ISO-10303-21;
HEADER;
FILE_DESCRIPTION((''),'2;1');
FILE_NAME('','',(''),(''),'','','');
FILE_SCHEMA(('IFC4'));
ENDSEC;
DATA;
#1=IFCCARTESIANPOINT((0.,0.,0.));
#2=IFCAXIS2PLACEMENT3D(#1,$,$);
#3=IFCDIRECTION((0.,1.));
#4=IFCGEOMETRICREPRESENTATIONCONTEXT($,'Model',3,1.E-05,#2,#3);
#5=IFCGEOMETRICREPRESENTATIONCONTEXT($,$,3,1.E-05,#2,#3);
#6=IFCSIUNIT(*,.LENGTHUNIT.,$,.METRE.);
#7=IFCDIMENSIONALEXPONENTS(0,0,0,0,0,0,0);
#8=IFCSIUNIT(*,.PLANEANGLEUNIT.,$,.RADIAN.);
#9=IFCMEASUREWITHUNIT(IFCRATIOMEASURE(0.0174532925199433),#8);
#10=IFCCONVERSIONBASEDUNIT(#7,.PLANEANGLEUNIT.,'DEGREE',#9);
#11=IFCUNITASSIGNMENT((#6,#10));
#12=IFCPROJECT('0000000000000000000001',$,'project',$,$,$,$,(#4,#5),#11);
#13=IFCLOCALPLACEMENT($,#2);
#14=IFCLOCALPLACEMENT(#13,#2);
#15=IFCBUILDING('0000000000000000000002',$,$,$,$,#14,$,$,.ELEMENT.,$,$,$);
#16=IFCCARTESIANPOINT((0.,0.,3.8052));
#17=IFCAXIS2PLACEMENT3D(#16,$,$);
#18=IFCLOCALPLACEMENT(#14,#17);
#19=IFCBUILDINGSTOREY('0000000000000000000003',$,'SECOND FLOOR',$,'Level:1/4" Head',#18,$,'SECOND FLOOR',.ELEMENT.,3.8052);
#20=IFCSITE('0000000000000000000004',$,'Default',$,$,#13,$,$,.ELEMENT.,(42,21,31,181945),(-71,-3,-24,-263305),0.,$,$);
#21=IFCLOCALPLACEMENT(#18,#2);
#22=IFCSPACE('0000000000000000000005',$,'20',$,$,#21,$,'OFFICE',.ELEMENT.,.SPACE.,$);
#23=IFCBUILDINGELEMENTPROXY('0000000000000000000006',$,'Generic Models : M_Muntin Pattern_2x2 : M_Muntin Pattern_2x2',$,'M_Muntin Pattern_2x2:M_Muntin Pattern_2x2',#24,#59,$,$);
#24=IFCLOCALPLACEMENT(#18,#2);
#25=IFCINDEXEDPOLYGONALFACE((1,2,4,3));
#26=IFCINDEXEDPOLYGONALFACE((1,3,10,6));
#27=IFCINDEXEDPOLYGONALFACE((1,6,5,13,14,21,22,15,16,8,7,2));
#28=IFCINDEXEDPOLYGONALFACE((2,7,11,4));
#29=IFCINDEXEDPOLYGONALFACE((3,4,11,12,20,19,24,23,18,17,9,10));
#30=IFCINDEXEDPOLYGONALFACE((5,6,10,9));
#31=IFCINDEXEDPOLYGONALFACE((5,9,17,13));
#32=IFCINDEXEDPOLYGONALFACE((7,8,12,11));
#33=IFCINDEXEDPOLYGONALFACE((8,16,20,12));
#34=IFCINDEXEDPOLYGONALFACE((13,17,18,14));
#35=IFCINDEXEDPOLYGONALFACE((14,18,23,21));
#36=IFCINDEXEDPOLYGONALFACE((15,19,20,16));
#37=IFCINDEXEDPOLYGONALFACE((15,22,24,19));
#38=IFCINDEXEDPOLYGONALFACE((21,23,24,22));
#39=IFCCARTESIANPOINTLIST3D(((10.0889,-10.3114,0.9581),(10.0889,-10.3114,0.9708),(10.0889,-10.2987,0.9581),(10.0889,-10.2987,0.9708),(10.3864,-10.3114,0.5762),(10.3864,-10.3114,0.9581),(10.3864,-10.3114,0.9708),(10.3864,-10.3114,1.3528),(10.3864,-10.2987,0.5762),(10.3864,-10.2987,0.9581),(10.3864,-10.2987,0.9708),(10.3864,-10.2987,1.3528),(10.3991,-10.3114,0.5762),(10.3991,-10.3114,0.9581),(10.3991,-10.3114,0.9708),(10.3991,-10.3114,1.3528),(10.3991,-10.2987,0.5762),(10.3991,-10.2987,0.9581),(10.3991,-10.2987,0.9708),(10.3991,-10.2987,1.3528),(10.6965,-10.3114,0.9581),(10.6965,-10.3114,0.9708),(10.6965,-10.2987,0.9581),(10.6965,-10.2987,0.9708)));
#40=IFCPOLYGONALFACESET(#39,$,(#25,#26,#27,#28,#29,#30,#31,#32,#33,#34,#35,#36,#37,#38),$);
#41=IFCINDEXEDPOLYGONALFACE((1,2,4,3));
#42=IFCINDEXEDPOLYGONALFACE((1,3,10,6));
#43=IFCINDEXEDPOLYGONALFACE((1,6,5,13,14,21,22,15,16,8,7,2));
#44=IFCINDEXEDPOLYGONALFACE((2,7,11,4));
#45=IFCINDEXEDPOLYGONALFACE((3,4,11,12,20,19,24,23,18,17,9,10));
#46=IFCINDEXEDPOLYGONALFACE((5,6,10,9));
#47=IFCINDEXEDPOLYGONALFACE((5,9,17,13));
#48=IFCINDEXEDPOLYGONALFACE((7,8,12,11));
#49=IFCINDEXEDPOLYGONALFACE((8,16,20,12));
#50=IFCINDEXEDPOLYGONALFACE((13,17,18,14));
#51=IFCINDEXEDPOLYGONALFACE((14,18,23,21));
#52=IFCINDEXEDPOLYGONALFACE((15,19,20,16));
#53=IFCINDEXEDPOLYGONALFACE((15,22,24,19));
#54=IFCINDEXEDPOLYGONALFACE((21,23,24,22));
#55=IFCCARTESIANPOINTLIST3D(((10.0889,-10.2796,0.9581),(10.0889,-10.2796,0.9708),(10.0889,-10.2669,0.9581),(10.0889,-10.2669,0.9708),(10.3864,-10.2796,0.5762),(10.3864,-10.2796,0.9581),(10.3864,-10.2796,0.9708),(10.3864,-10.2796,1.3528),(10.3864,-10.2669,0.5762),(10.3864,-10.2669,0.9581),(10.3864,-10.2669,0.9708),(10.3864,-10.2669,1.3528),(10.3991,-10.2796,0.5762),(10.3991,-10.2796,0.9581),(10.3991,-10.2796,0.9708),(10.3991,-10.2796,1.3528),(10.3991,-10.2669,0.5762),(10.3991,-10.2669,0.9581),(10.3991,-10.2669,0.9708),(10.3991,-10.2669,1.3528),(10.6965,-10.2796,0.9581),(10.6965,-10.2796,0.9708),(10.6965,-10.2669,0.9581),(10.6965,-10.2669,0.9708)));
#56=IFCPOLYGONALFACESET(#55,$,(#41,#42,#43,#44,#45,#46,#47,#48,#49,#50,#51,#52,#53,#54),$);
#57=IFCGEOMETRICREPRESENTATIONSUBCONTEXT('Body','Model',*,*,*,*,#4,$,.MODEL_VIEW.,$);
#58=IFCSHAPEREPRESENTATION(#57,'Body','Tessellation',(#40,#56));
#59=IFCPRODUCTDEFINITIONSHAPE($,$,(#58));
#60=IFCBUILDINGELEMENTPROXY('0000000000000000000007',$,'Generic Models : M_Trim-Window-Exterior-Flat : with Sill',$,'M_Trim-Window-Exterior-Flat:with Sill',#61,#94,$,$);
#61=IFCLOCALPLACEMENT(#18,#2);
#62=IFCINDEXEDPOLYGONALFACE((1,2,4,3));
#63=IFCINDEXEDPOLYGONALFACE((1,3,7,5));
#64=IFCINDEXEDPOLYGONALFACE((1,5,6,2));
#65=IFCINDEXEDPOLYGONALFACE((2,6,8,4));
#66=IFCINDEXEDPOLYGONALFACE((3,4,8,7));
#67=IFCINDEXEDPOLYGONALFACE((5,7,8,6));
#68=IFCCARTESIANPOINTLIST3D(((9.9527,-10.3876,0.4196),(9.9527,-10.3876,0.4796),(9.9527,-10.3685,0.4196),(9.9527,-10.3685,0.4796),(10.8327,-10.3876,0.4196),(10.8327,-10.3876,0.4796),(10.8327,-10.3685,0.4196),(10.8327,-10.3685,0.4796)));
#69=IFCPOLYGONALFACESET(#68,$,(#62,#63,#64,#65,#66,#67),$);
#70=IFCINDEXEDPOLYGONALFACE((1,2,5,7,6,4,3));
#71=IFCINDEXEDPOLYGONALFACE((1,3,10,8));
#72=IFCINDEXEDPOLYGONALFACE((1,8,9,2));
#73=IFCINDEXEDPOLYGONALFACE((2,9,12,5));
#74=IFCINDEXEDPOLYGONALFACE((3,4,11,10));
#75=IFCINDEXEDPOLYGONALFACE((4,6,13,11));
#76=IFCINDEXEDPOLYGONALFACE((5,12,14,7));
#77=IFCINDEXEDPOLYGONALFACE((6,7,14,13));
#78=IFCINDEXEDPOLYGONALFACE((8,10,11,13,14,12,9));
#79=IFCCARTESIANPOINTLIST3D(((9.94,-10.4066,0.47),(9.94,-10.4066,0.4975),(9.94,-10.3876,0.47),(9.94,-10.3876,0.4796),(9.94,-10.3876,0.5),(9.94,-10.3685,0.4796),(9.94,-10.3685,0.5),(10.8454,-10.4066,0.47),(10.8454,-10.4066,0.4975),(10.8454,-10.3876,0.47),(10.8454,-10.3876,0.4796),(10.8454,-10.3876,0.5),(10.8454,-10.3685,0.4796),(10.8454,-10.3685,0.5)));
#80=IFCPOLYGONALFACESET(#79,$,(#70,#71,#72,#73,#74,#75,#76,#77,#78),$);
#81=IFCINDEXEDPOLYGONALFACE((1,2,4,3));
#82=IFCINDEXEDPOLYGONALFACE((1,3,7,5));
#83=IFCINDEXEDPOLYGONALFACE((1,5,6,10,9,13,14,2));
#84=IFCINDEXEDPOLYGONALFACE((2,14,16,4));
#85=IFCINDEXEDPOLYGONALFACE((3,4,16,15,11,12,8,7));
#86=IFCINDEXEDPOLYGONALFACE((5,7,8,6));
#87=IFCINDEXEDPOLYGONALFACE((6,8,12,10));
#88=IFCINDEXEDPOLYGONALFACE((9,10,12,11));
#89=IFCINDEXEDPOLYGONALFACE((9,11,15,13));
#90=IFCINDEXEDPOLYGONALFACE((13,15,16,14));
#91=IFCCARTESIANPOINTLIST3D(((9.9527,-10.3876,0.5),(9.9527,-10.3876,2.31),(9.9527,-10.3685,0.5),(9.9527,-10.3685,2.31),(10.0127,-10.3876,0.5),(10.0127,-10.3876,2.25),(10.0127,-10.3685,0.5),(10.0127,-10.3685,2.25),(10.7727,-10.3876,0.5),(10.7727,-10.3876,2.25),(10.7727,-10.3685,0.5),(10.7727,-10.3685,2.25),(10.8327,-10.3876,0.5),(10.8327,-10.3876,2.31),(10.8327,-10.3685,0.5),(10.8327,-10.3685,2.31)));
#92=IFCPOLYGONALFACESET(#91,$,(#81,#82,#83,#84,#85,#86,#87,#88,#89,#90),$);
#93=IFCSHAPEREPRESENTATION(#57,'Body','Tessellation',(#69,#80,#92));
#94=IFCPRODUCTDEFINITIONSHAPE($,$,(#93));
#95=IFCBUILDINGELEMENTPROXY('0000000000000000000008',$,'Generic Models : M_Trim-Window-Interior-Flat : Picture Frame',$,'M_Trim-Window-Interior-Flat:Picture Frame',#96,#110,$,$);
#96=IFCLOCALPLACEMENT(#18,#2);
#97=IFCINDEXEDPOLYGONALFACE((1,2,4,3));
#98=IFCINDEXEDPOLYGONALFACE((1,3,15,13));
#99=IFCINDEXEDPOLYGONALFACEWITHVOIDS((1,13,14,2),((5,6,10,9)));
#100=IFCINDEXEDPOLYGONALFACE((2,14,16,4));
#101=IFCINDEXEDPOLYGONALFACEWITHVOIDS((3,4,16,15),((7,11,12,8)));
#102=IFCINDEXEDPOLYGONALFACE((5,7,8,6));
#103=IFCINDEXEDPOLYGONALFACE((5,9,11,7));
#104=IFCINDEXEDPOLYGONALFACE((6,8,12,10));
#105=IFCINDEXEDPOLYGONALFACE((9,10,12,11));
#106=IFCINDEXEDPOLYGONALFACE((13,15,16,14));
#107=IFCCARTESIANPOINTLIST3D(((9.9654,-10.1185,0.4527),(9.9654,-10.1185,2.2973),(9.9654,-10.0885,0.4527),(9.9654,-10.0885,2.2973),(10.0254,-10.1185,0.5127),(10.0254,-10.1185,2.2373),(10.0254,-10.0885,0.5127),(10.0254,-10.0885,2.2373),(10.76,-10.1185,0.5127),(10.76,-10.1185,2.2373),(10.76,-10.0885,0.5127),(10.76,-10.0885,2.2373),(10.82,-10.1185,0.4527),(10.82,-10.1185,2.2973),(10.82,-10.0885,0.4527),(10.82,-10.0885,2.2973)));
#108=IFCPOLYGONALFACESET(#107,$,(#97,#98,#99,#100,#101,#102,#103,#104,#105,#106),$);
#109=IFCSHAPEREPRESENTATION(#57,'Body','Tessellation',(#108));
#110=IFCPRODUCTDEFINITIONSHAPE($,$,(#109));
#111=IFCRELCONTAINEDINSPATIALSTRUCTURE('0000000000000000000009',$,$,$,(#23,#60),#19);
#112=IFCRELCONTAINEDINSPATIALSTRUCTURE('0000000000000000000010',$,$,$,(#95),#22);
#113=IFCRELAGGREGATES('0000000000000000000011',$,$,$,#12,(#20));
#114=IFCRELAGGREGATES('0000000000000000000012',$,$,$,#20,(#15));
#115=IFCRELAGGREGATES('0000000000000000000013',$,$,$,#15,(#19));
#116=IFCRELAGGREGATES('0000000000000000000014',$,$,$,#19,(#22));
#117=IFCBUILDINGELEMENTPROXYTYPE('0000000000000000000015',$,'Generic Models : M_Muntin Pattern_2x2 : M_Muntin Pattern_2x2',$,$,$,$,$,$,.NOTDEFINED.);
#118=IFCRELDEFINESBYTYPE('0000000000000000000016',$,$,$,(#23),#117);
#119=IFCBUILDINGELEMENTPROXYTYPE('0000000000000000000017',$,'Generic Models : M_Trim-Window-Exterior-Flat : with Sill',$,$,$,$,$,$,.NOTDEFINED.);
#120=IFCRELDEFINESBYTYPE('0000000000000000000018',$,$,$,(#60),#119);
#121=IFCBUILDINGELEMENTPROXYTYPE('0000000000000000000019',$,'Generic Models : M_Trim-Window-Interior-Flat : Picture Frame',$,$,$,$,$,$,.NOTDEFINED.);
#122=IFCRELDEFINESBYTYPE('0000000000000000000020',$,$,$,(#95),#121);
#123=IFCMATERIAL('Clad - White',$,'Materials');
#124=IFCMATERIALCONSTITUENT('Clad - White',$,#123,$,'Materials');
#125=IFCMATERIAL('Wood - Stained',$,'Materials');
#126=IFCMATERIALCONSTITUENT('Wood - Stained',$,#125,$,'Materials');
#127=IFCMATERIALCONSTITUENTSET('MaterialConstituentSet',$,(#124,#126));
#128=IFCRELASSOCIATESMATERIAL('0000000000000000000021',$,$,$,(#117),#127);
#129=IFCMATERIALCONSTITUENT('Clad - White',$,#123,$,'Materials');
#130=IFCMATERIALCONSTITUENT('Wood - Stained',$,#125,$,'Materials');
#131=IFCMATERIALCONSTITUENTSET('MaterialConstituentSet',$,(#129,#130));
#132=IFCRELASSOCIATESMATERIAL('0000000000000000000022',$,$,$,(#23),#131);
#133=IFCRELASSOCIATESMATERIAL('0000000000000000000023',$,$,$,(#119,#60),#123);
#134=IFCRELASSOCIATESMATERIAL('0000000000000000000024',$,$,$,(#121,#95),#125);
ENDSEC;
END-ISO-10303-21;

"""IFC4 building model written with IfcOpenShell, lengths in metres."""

from ifc_helpers import new_model, entity, si_unit, converted_unit, direction, frame, frame_2d, origin, place, context, subcontext, project, spatial, polyline, rectangle, outline, extrude, source, transform, mapped, material, constituent, constituent_set, type_object, type_shapes, element, save


model = new_model("IFC4")

# Units and contexts
model_context = context("Model", 3, precision=1e-05, world=origin(), true_north=direction((0.0, 1.0)))
context_of_model = context(None, 3, precision=1e-05, world=origin(), true_north=direction((0.0, 1.0)))
body_context = subcontext(model_context, "Body", "Model", "MODEL_VIEW")
ifc_project = project(units=[si_unit("LENGTHUNIT", "METRE"), converted_unit("PLANEANGLEUNIT", "DEGREE", entity("IfcRatioMeasure", 0.0174532925199433), si_unit("PLANEANGLEUNIT", "RADIAN"), dimensions=[0, 0, 0, 0, 0, 0, 0])], contexts=[model_context, context_of_model])

# Site, building, storey
site_placement = place(None, origin())
site = spatial("IfcSite", under=ifc_project, at=site_placement, Name="Default", CompositionType="ELEMENT", RefLatitude=(42, 21, 31, 181945), RefLongitude=(-71, -3, -24, -263305), RefElevation=0.0)
building_placement = place(site_placement, origin())
building = spatial("IfcBuilding", under=site, at=building_placement, CompositionType="ELEMENT")
storey_placement = place(building_placement, frame((0.0, 0.0, 3.8052)))
storey = spatial("IfcBuildingStorey", under=building, at=storey_placement, Name="SECOND FLOOR", ObjectType="Level:1/4\" Head", LongName="SECOND FLOOR", CompositionType="ELEMENT", Elevation=3.8052)

# Shared definitions
ifc_material_1 = material(Name="Wood - Stained", Category="Materials")

# Building element proxies
ifc_material_2 = material(Name="Clad - White", Category="Materials")
ifc_constituent_1 = constituent(ifc_material_2, Name="Clad - White", Category="Materials")
ifc_constituent_2 = constituent(ifc_material_1, Name="Wood - Stained", Category="Materials")
ifc_constituent_set_1 = constituent_set(constituents=[ifc_constituent_1, ifc_constituent_2], Name="MaterialConstituentSet")
building_element_proxy_type_1 = type_object("IfcBuildingElementProxyType", Name="Generic Models : M_Muntin Pattern_2x2 : M_Muntin Pattern_2x2", PredefinedType="NOTDEFINED", material=ifc_constituent_set_1)
shared_shape_1 = source(origin(), body_context, "Body", "SweptSolid", [
    extrude(outline(polyline([(0.0064, -0.0064), (0.3883, -0.0064), (0.3883, 0.0063), (0.0064, 0.0063), (0.0064, 0.3038), (-0.0063, 0.3038), (-0.0063, 0.0063), (-0.3883, 0.0063), (-0.3883, -0.0064), (-0.0063, -0.0064), (-0.0063, -0.3038), (0.0064, -0.3038), (0.0064, -0.0064)])), frame((0.0, -0.0222, 0.3883), z_axis=(0.0, 1.0, 0.0), x_axis=(0.0, 0.0, 1.0)), (0.0, 0.0, 1.0), 0.0127),
    extrude(outline(polyline([(0.0064, -0.0064), (0.3883, -0.0064), (0.3883, 0.0063), (0.0064, 0.0063), (0.0064, 0.3038), (-0.0063, 0.3038), (-0.0063, 0.0063), (-0.3883, 0.0063), (-0.3883, -0.0064), (-0.0063, -0.0064), (-0.0063, -0.3038), (0.0064, -0.3038), (0.0064, -0.0064)])), frame((0.0, 0.0095, 0.3883), z_axis=(0.0, 1.0, 0.0), x_axis=(0.0, 0.0, 1.0)), (0.0, 0.0, 1.0), 0.0127),
])
type_shapes(building_element_proxy_type_1, [shared_shape_1])
ifc_constituent_3 = constituent(ifc_material_2, Name="Clad - White", Category="Materials")
ifc_constituent_4 = constituent(ifc_material_1, Name="Wood - Stained", Category="Materials")
ifc_constituent_set_2 = constituent_set(constituents=[ifc_constituent_3, ifc_constituent_4], Name="MaterialConstituentSet")
proxy_1_placement = place(storey_placement, frame((10.3927, -10.2891, 0.5762)))
element("IfcBuildingElementProxy", 1, at=proxy_1_placement, inside=storey, type_object=building_element_proxy_type_1, material=ifc_constituent_set_2, Name="Generic Models : M_Muntin Pattern_2x2 : M_Muntin Pattern_2x2", ObjectType="M_Muntin Pattern_2x2:M_Muntin Pattern_2x2", context=body_context, shape_type="MappedRepresentation", body=[
    mapped(shared_shape_1, transform((0.0, 0.0, 0.0), scale=1.0)),
])
building_element_proxy_type_2 = type_object("IfcBuildingElementProxyType", Name="Generic Models : M_Trim-Window-Exterior-Flat : with Sill", PredefinedType="NOTDEFINED", material=ifc_material_2)
shared_shape_2 = source(origin(), body_context, "Body", "SweptSolid", [
    extrude(rectangle(XDim=0.06, YDim=0.88, at=frame_2d((0.0, 0.0), x_axis=(1.0, 0.0))), frame((0.0, 1.8004, 0.0), z_axis=(0.0, 0.0, 1.0), x_axis=(0.0, 1.0, 0.0)), (0.0, 0.0, 1.0), 0.0191),
    extrude(outline(polyline([(-0.0152, -0.019), (0.0123, -0.019), (0.0148, 0.0), (0.0148, 0.019), (-0.0057, 0.019), (-0.0057, 0.0), (-0.0152, 0.0), (-0.0152, -0.019)])), frame((-0.4527, 1.7648, 0.019), z_axis=(1.0, 0.0, 0.0), x_axis=(0.0, -1.0, 0.0)), (0.0, 0.0, 1.0), 0.9054),
    extrude(outline(polyline([(-0.44, -0.92), (0.44, -0.92), (0.44, 0.89), (0.38, 0.89), (0.38, -0.86), (-0.38, -0.86), (-0.38, 0.89), (-0.44, 0.89), (-0.44, -0.92)])), frame((0.0, 0.86, 0.0)), (0.0, 0.0, 1.0), 0.0191),
])
type_shapes(building_element_proxy_type_2, [shared_shape_2])
proxy_2_placement = place(storey_placement, frame((10.3927, -10.3685, 2.25), z_axis=(0.0, -1.0, 0.0), x_axis=(-1.0, 0.0, 0.0)))
element("IfcBuildingElementProxy", 2, at=proxy_2_placement, inside=storey, type_object=building_element_proxy_type_2, material=ifc_material_2, Name="Generic Models : M_Trim-Window-Exterior-Flat : with Sill", ObjectType="M_Trim-Window-Exterior-Flat:with Sill", context=body_context, shape_type="MappedRepresentation", body=[
    mapped(shared_shape_2, transform((0.0, 0.0, 0.0), scale=1.0)),
])

# Shared definitions
space_placement = place(storey_placement, origin())
space = spatial("IfcSpace", under=storey, at=space_placement, Name="20", LongName="OFFICE", CompositionType="ELEMENT", PredefinedType="SPACE")

# Building element proxy
building_element_proxy_type_3 = type_object("IfcBuildingElementProxyType", Name="Generic Models : M_Trim-Window-Interior-Flat : Picture Frame", PredefinedType="NOTDEFINED", material=ifc_material_1)
shared_shape_3 = source(origin(), body_context, "Body", "SweptSolid", [
    extrude(outline(polyline([(-0.9223, -0.4273), (0.9223, -0.4273), (0.9223, 0.4273), (-0.9223, 0.4273), (-0.9223, -0.4273)]), holes=[polyline([(-0.8623, -0.3673), (-0.8623, 0.3673), (0.8623, 0.3673), (0.8623, -0.3673), (-0.8623, -0.3673)])]), frame((0.0, 0.875, 0.0), z_axis=(0.0, 0.0, 1.0), x_axis=(0.0, 1.0, 0.0)), (0.0, 0.0, 1.0), 0.03),
])
type_shapes(building_element_proxy_type_3, [shared_shape_3])
proxy_3_placement = place(space_placement, frame((10.3927, -10.1185, 2.25), z_axis=(0.0, 1.0, 0.0), x_axis=(1.0, 0.0, 0.0)))
element("IfcBuildingElementProxy", 3, at=proxy_3_placement, inside=space, type_object=building_element_proxy_type_3, material=ifc_material_1, Name="Generic Models : M_Trim-Window-Interior-Flat : Picture Frame", ObjectType="M_Trim-Window-Interior-Flat:Picture Frame", context=body_context, shape_type="MappedRepresentation", body=[
    mapped(shared_shape_3, transform((0.0, 0.0, 0.0), scale=1.0)),
])

save(model, "model.ifc")
